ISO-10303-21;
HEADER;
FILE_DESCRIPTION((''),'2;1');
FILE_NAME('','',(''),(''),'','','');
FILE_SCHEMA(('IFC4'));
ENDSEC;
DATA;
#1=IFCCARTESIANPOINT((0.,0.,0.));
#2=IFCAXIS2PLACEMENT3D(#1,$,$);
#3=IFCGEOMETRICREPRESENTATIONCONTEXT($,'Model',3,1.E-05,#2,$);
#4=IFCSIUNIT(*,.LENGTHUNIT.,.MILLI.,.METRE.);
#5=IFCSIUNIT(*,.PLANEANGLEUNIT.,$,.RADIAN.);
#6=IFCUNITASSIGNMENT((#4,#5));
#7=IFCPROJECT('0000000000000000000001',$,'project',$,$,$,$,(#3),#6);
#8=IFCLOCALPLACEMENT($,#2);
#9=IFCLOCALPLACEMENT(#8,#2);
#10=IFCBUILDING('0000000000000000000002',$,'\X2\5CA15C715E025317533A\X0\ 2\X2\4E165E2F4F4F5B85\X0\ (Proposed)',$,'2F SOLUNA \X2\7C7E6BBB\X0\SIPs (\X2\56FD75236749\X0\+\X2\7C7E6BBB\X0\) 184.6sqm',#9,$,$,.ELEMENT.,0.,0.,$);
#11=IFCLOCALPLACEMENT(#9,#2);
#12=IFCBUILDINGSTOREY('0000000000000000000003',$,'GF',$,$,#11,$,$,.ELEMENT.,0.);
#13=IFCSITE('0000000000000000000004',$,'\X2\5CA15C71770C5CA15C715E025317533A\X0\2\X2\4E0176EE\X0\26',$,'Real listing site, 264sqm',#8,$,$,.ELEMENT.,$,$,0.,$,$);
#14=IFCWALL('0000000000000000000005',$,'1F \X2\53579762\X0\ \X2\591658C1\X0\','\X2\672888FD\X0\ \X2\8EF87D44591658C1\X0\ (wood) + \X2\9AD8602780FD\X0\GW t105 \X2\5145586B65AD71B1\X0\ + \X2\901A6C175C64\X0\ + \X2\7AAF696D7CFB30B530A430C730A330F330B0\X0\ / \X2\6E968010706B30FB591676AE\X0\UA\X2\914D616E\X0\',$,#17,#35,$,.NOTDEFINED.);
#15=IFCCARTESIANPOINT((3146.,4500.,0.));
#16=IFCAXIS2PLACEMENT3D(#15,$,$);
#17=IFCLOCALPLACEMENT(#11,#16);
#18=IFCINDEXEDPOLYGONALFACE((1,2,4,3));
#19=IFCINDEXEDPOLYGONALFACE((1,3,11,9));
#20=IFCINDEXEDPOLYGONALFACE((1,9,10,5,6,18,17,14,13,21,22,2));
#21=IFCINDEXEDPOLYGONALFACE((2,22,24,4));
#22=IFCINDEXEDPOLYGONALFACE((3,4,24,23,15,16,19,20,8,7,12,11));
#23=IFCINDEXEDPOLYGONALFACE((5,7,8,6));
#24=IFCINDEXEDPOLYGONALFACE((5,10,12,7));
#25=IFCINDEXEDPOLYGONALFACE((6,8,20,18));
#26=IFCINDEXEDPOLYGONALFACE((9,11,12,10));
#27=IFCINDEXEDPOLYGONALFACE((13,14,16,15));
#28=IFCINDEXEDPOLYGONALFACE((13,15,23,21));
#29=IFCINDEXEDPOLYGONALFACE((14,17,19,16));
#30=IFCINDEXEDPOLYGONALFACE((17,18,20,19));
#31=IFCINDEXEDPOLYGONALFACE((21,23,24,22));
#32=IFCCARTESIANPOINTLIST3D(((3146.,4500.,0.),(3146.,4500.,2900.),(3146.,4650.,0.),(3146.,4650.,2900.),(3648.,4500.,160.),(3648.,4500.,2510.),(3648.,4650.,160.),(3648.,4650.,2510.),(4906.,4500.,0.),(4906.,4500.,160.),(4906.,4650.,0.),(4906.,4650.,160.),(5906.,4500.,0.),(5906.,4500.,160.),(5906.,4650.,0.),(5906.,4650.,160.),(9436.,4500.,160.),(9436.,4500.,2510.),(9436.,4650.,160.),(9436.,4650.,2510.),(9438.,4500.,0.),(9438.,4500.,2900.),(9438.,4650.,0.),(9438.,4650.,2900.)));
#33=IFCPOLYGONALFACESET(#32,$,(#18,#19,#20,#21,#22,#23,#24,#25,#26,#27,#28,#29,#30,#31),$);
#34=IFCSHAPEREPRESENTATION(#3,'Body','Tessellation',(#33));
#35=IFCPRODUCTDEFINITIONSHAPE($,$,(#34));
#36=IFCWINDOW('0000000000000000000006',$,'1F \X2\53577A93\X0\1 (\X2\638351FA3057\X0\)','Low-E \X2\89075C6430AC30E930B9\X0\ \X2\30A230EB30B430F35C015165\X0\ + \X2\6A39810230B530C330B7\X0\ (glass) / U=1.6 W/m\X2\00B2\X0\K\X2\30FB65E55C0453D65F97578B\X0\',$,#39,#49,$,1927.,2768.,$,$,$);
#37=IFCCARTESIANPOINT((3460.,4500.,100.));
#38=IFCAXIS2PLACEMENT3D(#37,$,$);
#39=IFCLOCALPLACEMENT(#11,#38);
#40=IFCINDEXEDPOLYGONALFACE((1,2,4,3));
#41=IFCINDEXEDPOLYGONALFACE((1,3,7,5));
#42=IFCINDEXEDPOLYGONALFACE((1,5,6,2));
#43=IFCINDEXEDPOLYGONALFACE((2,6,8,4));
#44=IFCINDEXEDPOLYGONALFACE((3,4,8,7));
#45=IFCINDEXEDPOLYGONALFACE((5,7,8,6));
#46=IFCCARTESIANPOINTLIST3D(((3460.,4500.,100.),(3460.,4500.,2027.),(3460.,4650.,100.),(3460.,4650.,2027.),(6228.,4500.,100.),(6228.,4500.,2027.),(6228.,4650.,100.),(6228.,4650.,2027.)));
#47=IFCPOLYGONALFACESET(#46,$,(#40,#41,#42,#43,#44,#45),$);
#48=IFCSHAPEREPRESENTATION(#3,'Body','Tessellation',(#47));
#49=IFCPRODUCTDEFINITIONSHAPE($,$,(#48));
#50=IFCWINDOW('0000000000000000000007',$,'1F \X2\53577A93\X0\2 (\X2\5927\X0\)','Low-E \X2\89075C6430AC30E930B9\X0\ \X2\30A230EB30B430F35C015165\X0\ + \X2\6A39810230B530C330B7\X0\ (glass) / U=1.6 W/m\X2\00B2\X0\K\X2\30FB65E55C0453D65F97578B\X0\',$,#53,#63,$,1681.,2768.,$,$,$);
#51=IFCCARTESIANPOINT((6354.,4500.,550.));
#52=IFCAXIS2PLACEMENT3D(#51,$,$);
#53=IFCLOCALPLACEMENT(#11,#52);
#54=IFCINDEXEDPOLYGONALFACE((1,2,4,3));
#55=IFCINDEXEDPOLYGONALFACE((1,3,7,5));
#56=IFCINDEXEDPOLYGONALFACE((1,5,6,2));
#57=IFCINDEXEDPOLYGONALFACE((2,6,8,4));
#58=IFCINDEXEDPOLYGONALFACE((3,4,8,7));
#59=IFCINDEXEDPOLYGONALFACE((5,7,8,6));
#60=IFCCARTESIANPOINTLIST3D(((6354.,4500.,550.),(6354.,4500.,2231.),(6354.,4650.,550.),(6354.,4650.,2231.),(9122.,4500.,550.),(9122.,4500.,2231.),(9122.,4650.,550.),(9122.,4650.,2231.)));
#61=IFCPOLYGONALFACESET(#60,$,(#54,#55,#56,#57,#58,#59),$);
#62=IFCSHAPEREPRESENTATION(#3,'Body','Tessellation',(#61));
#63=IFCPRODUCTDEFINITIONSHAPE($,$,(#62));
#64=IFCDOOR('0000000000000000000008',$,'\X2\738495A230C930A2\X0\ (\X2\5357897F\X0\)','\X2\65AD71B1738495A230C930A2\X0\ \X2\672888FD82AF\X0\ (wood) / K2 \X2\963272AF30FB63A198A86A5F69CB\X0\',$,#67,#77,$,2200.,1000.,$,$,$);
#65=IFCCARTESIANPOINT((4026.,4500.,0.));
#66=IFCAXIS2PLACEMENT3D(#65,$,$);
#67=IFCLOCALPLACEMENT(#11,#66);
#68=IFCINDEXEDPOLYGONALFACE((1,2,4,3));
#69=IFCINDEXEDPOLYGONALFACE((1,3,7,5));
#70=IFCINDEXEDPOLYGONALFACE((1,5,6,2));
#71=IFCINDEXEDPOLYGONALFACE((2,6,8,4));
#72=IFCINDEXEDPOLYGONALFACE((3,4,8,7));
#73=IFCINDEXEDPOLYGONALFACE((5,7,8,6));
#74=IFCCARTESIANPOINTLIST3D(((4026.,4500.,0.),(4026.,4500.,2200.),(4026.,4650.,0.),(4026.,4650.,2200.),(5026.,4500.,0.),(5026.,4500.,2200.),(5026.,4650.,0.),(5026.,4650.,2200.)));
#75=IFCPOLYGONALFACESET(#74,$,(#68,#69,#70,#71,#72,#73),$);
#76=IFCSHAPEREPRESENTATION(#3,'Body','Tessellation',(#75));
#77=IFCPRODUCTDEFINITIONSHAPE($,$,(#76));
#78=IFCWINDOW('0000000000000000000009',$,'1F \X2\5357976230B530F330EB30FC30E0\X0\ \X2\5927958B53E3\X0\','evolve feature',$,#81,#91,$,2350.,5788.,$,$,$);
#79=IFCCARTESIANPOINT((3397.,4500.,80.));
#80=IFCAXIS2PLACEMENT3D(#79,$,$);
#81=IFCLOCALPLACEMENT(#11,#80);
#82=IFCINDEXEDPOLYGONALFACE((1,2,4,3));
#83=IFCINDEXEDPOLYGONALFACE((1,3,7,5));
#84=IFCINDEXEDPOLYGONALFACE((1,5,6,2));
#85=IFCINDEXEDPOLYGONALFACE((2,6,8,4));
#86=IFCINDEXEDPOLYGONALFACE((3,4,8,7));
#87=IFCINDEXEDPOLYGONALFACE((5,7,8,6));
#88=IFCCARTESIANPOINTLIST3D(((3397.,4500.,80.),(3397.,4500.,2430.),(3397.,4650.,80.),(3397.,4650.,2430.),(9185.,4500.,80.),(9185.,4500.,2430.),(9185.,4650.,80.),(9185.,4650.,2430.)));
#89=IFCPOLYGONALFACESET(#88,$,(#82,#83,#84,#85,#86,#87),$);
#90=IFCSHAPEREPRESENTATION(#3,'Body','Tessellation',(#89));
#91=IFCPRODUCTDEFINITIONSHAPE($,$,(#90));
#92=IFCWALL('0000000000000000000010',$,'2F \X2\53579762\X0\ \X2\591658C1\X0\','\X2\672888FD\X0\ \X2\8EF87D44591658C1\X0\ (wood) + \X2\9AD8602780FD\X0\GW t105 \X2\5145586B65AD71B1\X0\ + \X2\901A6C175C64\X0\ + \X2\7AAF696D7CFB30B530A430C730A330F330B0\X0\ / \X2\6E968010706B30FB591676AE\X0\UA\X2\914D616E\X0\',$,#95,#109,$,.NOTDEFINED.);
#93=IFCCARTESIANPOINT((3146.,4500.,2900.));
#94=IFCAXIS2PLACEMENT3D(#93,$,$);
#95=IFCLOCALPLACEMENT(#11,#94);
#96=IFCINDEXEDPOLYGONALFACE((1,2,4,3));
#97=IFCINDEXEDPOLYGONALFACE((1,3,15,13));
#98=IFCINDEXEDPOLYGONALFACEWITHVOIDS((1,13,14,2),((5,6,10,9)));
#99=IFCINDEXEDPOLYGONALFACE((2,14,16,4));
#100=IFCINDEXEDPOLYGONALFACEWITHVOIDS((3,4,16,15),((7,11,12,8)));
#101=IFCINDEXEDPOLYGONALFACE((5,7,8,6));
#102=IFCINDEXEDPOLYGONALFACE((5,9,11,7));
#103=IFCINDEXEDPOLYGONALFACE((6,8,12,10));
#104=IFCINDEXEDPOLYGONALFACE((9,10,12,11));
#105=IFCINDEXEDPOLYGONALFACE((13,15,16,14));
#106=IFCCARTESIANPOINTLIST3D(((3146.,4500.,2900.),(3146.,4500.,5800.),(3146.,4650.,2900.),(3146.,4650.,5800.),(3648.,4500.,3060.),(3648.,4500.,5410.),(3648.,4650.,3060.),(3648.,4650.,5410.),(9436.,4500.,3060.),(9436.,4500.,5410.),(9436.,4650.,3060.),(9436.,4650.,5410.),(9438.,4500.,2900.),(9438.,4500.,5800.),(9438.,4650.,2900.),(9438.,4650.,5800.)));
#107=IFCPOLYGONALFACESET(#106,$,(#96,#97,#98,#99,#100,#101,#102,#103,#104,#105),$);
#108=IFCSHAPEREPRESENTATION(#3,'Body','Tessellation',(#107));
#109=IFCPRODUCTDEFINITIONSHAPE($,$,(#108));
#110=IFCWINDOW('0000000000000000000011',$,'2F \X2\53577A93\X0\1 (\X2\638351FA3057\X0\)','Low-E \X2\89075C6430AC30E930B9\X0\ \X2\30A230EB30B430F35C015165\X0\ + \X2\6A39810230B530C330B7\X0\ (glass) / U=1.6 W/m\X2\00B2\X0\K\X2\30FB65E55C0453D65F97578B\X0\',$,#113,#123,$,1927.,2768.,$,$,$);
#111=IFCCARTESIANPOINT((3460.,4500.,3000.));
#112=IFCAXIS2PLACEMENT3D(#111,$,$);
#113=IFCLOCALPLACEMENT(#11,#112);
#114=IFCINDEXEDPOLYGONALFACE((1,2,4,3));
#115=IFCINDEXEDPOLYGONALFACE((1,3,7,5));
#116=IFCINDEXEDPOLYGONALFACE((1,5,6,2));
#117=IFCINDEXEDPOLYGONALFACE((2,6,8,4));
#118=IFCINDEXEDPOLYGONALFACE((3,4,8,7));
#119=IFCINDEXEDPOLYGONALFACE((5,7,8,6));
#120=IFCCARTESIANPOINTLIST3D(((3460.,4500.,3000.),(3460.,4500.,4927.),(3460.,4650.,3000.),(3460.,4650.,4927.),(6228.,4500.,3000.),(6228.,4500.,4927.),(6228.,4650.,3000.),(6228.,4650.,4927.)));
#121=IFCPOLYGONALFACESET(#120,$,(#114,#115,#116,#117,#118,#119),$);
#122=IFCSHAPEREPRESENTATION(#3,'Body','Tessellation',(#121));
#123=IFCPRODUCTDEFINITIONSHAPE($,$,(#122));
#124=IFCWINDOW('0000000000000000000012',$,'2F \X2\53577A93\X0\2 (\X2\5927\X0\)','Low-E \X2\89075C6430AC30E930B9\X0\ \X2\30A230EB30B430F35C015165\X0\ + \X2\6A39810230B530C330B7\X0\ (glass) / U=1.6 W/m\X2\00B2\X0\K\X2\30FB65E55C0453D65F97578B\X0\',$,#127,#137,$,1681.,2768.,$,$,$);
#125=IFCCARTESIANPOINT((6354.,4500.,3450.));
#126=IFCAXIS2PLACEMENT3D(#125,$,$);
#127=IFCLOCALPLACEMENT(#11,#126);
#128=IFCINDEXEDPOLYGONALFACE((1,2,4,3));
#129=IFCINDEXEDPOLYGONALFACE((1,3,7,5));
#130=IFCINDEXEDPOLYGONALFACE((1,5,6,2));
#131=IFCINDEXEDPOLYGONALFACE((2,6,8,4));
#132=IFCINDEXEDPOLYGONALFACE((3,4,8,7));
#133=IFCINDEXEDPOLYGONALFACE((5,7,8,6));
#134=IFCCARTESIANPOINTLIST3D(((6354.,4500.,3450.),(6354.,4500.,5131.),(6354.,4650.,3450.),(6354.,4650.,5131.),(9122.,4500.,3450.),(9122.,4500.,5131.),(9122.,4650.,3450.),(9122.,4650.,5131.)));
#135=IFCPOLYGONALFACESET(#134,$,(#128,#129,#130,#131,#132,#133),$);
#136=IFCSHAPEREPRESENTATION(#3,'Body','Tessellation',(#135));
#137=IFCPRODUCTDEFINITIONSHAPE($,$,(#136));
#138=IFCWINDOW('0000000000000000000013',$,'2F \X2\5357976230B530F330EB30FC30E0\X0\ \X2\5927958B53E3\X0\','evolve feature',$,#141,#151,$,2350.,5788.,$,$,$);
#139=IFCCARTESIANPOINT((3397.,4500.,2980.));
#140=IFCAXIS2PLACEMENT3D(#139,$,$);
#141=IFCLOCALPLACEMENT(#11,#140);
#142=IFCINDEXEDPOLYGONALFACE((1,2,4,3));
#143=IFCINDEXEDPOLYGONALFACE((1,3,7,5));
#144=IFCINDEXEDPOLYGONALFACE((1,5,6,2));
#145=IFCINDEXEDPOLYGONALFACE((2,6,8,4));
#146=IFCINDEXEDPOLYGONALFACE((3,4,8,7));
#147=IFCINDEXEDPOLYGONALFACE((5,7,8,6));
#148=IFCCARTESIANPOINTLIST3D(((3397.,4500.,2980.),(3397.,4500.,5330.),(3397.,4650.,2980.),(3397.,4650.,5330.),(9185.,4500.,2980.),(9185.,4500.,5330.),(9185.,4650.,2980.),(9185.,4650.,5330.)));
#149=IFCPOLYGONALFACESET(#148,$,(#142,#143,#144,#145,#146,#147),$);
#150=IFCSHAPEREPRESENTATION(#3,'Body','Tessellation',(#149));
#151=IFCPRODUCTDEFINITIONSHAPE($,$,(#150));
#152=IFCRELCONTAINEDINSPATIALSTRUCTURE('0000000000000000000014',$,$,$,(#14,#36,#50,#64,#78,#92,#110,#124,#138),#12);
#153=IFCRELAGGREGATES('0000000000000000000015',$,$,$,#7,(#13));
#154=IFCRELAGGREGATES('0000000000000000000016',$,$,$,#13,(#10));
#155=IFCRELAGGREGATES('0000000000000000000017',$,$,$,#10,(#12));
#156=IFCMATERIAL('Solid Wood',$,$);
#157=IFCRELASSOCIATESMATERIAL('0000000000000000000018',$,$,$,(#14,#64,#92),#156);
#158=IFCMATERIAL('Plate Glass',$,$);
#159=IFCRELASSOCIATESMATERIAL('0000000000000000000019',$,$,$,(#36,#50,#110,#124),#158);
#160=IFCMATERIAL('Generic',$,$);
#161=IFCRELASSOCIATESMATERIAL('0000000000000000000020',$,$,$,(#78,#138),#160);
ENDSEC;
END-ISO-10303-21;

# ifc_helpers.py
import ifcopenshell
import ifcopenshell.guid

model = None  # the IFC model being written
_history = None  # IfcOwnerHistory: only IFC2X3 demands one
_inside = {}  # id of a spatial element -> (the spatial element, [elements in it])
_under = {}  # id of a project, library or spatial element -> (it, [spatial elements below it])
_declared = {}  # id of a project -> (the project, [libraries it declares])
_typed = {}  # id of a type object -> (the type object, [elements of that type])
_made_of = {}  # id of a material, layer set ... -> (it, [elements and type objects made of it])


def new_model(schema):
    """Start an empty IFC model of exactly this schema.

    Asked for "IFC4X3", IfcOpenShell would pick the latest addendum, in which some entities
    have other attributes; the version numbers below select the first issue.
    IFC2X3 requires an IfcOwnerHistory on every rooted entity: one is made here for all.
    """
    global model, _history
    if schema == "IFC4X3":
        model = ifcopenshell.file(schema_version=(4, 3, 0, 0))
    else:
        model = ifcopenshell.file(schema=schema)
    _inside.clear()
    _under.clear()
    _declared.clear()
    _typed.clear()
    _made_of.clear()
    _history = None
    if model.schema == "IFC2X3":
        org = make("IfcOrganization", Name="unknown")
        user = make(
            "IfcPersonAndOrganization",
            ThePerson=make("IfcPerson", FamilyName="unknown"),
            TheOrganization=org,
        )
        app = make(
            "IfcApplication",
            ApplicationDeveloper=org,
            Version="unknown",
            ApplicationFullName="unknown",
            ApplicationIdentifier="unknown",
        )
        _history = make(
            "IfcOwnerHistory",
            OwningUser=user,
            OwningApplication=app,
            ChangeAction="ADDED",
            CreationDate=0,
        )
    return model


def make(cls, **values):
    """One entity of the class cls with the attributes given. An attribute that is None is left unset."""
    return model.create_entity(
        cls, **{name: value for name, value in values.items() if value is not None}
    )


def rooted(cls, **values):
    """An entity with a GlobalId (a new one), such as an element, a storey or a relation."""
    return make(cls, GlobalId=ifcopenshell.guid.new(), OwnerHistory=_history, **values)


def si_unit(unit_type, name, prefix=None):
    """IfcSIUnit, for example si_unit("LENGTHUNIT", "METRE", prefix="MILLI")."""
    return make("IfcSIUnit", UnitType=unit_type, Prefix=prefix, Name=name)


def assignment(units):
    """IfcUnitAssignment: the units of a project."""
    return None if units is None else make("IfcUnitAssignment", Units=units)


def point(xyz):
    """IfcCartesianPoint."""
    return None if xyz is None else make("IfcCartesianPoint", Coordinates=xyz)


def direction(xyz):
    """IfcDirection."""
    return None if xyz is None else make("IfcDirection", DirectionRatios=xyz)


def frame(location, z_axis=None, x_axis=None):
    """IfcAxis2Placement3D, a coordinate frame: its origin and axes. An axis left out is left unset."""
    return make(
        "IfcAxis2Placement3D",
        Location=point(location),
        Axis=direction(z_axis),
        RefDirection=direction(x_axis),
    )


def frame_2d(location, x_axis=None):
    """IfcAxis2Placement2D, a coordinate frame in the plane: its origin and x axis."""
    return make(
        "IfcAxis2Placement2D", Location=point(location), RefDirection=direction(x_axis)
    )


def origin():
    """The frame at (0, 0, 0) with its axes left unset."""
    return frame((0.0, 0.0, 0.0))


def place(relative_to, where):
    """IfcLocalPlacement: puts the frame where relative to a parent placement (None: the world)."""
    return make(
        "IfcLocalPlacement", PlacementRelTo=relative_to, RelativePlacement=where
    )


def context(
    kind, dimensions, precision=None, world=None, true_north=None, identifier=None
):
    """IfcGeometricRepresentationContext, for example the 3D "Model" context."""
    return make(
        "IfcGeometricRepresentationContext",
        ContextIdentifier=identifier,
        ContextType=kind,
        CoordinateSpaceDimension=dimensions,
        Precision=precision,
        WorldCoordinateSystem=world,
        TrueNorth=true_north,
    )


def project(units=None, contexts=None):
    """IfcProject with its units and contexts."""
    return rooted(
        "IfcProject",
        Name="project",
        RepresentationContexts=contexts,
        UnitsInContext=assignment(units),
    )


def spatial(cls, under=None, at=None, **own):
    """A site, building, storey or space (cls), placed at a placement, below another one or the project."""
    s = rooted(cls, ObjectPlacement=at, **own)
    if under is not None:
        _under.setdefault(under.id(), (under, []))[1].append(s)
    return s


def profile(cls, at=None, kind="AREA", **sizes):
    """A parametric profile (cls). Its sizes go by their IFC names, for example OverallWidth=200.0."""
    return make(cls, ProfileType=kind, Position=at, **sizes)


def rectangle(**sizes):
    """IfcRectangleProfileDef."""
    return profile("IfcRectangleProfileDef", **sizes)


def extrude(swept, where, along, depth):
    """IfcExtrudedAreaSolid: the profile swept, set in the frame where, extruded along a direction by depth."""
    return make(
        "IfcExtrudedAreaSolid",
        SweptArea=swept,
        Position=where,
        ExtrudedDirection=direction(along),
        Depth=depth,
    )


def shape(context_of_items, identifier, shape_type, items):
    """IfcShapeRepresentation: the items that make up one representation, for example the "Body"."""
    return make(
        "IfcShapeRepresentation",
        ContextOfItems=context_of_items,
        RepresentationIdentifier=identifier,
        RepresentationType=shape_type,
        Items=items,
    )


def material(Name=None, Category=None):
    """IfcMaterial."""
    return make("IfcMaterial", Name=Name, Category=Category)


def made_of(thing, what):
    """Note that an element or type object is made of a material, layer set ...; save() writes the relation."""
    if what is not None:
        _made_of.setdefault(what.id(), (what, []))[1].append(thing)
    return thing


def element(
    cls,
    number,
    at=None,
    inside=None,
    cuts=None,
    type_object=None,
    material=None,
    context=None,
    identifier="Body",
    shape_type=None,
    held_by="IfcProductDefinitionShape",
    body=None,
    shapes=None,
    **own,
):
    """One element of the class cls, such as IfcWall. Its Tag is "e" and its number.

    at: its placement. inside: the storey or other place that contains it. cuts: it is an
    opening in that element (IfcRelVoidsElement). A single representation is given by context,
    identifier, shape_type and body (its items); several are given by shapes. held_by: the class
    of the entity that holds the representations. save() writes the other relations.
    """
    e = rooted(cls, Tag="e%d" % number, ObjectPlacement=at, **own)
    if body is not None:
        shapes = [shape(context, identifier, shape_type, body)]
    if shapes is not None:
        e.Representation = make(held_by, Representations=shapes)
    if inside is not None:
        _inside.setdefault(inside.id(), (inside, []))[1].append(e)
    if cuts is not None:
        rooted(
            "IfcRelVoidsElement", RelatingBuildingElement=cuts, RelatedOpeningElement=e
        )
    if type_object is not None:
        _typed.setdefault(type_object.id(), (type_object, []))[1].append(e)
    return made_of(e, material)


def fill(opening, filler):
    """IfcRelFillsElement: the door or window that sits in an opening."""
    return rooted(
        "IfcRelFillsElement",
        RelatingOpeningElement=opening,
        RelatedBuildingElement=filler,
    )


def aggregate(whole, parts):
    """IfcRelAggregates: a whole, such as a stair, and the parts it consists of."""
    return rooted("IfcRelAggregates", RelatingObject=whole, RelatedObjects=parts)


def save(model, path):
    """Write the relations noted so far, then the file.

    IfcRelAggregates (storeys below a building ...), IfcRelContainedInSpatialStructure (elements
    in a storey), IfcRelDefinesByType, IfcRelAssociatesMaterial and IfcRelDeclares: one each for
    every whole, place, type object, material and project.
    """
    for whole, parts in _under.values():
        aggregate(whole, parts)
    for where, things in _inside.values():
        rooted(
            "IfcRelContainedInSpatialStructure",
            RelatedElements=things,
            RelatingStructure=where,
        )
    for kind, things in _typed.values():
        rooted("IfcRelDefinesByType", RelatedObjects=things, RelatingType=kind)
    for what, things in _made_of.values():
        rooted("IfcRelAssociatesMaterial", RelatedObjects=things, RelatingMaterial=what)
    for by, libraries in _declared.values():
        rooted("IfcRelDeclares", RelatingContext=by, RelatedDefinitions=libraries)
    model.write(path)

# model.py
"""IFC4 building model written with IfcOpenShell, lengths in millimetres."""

from ifc_helpers import new_model, si_unit, frame, frame_2d, origin, place, context, project, spatial, rectangle, extrude, material, element, fill, save


model = new_model("IFC4")

# Units and contexts
model_context = context("Model", 3, precision=1e-05, world=origin())
ifc_project = project(units=[si_unit("LENGTHUNIT", "METRE", prefix="MILLI"), si_unit("PLANEANGLEUNIT", "RADIAN")], contexts=[model_context])

# Site, building, storey
site_placement = place(None, origin())
site = spatial("IfcSite", under=ifc_project, at=site_placement, Name="岡山県岡山市北区2丁目26", ObjectType="Real listing site, 264sqm", CompositionType="ELEMENT", RefElevation=0.0)
building_placement = place(site_placement, origin())
building = spatial("IfcBuilding", under=site, at=building_placement, Name="岡山市北区 2世帯住宅 (Proposed)", ObjectType="2F SOLUNA 籾殻SIPs (国産杉+籾殻) 184.6sqm", CompositionType="ELEMENT", ElevationOfRefHeight=0.0, ElevationOfTerrain=0.0)
storey_placement = place(building_placement, origin())
storey = spatial("IfcBuildingStorey", under=building, at=storey_placement, Name="GF", CompositionType="ELEMENT", Elevation=0.0)

# Shared definitions
ifc_material_1 = material(Name="Solid Wood")
ifc_material_2 = material(Name="Generic")

# Wall, openings, windows, door
wall_1_placement = place(storey_placement, frame((3146.0, 4500.0, 0.0)))
wall_1 = element("IfcWall", 1, at=wall_1_placement, inside=storey, material=ifc_material_1, Name="1F 南面 外壁", Description="木製 軸組外壁 (wood) + 高性能GW t105 充填断熱 + 通気層 + 窯業系サイディング / 準耐火・外皮UA配慮", PredefinedType="NOTDEFINED", context=model_context, shape_type="SweptSolid", body=[
    extrude(rectangle(XDim=6292.0, YDim=150.0, at=frame_2d((3146.0, 75.0))), frame((3146.0, 4500.0, 0.0)), (0.0, 0.0, 1.0), 2900.0),
])
opening_1_placement = place(storey_placement, frame((3460.0, 4500.0, 100.0)))
opening_1 = element("IfcOpeningElement", 2, at=opening_1_placement, cuts=wall_1, PredefinedType="NOTDEFINED", context=model_context, shape_type="SweptSolid", body=[
    extrude(rectangle(XDim=2768.0, YDim=150.0, at=frame_2d((1384.0, 75.0))), frame((3460.0, 4500.0, 100.0)), (0.0, 0.0, 1.0), 1927.0),
])
opening_2_placement = place(storey_placement, frame((6354.0, 4500.0, 550.0)))
opening_2 = element("IfcOpeningElement", 3, at=opening_2_placement, cuts=wall_1, PredefinedType="NOTDEFINED", context=model_context, shape_type="SweptSolid", body=[
    extrude(rectangle(XDim=2768.0, YDim=150.0, at=frame_2d((1384.0, 75.0))), frame((6354.0, 4500.0, 550.0)), (0.0, 0.0, 1.0), 1681.0),
])
opening_3_placement = place(storey_placement, frame((4026.0, 4500.0, 0.0)))
opening_3 = element("IfcOpeningElement", 4, at=opening_3_placement, cuts=wall_1, PredefinedType="NOTDEFINED", context=model_context, shape_type="SweptSolid", body=[
    extrude(rectangle(XDim=1000.0, YDim=150.0, at=frame_2d((500.0, 75.0))), frame((4026.0, 4500.0, 0.0)), (0.0, 0.0, 1.0), 2200.0),
])
opening_4_placement = place(storey_placement, frame((3397.0, 4500.0, 80.0)))
opening_4 = element("IfcOpeningElement", 5, at=opening_4_placement, cuts=wall_1, PredefinedType="NOTDEFINED", context=model_context, shape_type="SweptSolid", body=[
    extrude(rectangle(XDim=5788.0, YDim=150.0, at=frame_2d((2894.0, 75.0))), frame((3397.0, 4500.0, 80.0)), (0.0, 0.0, 1.0), 2350.0),
])
ifc_material_3 = material(Name="Plate Glass")
window_1_placement = place(storey_placement, frame((3460.0, 4500.0, 100.0)))
window_1 = element("IfcWindow", 6, at=window_1_placement, inside=storey, material=ifc_material_3, Name="1F 南窓1 (掃出し)", Description="Low-E 複層ガラス アルゴン封入 + 樹脂サッシ (glass) / U=1.6 W/m²K・日射取得型", OverallHeight=1927.0, OverallWidth=2768.0, context=model_context, shape_type="SweptSolid", body=[
    extrude(rectangle(XDim=2768.0, YDim=150.0, at=frame_2d((1384.0, 75.0))), frame((3460.0, 4500.0, 100.0)), (0.0, 0.0, 1.0), 1927.0),
])
fill(opening_1, window_1)
window_2_placement = place(storey_placement, frame((6354.0, 4500.0, 550.0)))
window_2 = element("IfcWindow", 7, at=window_2_placement, inside=storey, material=ifc_material_3, Name="1F 南窓2 (大)", Description="Low-E 複層ガラス アルゴン封入 + 樹脂サッシ (glass) / U=1.6 W/m²K・日射取得型", OverallHeight=1681.0, OverallWidth=2768.0, context=model_context, shape_type="SweptSolid", body=[
    extrude(rectangle(XDim=2768.0, YDim=150.0, at=frame_2d((1384.0, 75.0))), frame((6354.0, 4500.0, 550.0)), (0.0, 0.0, 1.0), 1681.0),
])
fill(opening_2, window_2)
door_placement = place(storey_placement, frame((4026.0, 4500.0, 0.0)))
door = element("IfcDoor", 8, at=door_placement, inside=storey, material=ifc_material_1, Name="玄関ドア (南西)", Description="断熱玄関ドア 木製芯 (wood) / K2 防犯・採風機構", OverallHeight=2200.0, OverallWidth=1000.0, context=model_context, shape_type="SweptSolid", body=[
    extrude(rectangle(XDim=1000.0, YDim=150.0, at=frame_2d((500.0, 75.0))), frame((4026.0, 4500.0, 0.0)), (0.0, 0.0, 1.0), 2200.0),
])
fill(opening_3, door)
window_3_placement = place(storey_placement, frame((3397.0, 4500.0, 80.0)))
window_3 = element("IfcWindow", 9, at=window_3_placement, inside=storey, material=ifc_material_2, Name="1F 南面サンルーム 大開口", Description="evolve feature", OverallHeight=2350.0, OverallWidth=5788.0, context=model_context, shape_type="SweptSolid", body=[
    extrude(rectangle(XDim=5788.0, YDim=150.0, at=frame_2d((2894.0, 75.0))), frame((3397.0, 4500.0, 80.0)), (0.0, 0.0, 1.0), 2350.0),
])
fill(opening_4, window_3)

# Wall, openings, windows
wall_2_placement = place(storey_placement, frame((3146.0, 4500.0, 2900.0)))
wall_2 = element("IfcWall", 10, at=wall_2_placement, inside=storey, material=ifc_material_1, Name="2F 南面 外壁", Description="木製 軸組外壁 (wood) + 高性能GW t105 充填断熱 + 通気層 + 窯業系サイディング / 準耐火・外皮UA配慮", PredefinedType="NOTDEFINED", context=model_context, shape_type="SweptSolid", body=[
    extrude(rectangle(XDim=6292.0, YDim=150.0, at=frame_2d((3146.0, 75.0))), frame((3146.0, 4500.0, 2900.0)), (0.0, 0.0, 1.0), 2900.0),
])
opening_5_placement = place(storey_placement, frame((3460.0, 4500.0, 3000.0)))
opening_5 = element("IfcOpeningElement", 11, at=opening_5_placement, cuts=wall_2, PredefinedType="NOTDEFINED", context=model_context, shape_type="SweptSolid", body=[
    extrude(rectangle(XDim=2768.0, YDim=150.0, at=frame_2d((1384.0, 75.0))), frame((3460.0, 4500.0, 3000.0)), (0.0, 0.0, 1.0), 1927.0),
])
opening_6_placement = place(storey_placement, frame((6354.0, 4500.0, 3450.0)))
opening_6 = element("IfcOpeningElement", 12, at=opening_6_placement, cuts=wall_2, PredefinedType="NOTDEFINED", context=model_context, shape_type="SweptSolid", body=[
    extrude(rectangle(XDim=2768.0, YDim=150.0, at=frame_2d((1384.0, 75.0))), frame((6354.0, 4500.0, 3450.0)), (0.0, 0.0, 1.0), 1681.0),
])
opening_7_placement = place(storey_placement, frame((3397.0, 4500.0, 2980.0)))
opening_7 = element("IfcOpeningElement", 13, at=opening_7_placement, cuts=wall_2, PredefinedType="NOTDEFINED", context=model_context, shape_type="SweptSolid", body=[
    extrude(rectangle(XDim=5788.0, YDim=150.0, at=frame_2d((2894.0, 75.0))), frame((3397.0, 4500.0, 2980.0)), (0.0, 0.0, 1.0), 2350.0),
])
window_4_placement = place(storey_placement, frame((3460.0, 4500.0, 3000.0)))
window_4 = element("IfcWindow", 14, at=window_4_placement, inside=storey, material=ifc_material_3, Name="2F 南窓1 (掃出し)", Description="Low-E 複層ガラス アルゴン封入 + 樹脂サッシ (glass) / U=1.6 W/m²K・日射取得型", OverallHeight=1927.0, OverallWidth=2768.0, context=model_context, shape_type="SweptSolid", body=[
    extrude(rectangle(XDim=2768.0, YDim=150.0, at=frame_2d((1384.0, 75.0))), frame((3460.0, 4500.0, 3000.0)), (0.0, 0.0, 1.0), 1927.0),
])
fill(opening_5, window_4)
window_5_placement = place(storey_placement, frame((6354.0, 4500.0, 3450.0)))
window_5 = element("IfcWindow", 15, at=window_5_placement, inside=storey, material=ifc_material_3, Name="2F 南窓2 (大)", Description="Low-E 複層ガラス アルゴン封入 + 樹脂サッシ (glass) / U=1.6 W/m²K・日射取得型", OverallHeight=1681.0, OverallWidth=2768.0, context=model_context, shape_type="SweptSolid", body=[
    extrude(rectangle(XDim=2768.0, YDim=150.0, at=frame_2d((1384.0, 75.0))), frame((6354.0, 4500.0, 3450.0)), (0.0, 0.0, 1.0), 1681.0),
])
fill(opening_6, window_5)
window_6_placement = place(storey_placement, frame((3397.0, 4500.0, 2980.0)))
window_6 = element("IfcWindow", 16, at=window_6_placement, inside=storey, material=ifc_material_2, Name="2F 南面サンルーム 大開口", Description="evolve feature", OverallHeight=2350.0, OverallWidth=5788.0, context=model_context, shape_type="SweptSolid", body=[
    extrude(rectangle(XDim=5788.0, YDim=150.0, at=frame_2d((2894.0, 75.0))), frame((3397.0, 4500.0, 2980.0)), (0.0, 0.0, 1.0), 2350.0),
])
fill(opening_7, window_6)

save(model, "model.ifc")
